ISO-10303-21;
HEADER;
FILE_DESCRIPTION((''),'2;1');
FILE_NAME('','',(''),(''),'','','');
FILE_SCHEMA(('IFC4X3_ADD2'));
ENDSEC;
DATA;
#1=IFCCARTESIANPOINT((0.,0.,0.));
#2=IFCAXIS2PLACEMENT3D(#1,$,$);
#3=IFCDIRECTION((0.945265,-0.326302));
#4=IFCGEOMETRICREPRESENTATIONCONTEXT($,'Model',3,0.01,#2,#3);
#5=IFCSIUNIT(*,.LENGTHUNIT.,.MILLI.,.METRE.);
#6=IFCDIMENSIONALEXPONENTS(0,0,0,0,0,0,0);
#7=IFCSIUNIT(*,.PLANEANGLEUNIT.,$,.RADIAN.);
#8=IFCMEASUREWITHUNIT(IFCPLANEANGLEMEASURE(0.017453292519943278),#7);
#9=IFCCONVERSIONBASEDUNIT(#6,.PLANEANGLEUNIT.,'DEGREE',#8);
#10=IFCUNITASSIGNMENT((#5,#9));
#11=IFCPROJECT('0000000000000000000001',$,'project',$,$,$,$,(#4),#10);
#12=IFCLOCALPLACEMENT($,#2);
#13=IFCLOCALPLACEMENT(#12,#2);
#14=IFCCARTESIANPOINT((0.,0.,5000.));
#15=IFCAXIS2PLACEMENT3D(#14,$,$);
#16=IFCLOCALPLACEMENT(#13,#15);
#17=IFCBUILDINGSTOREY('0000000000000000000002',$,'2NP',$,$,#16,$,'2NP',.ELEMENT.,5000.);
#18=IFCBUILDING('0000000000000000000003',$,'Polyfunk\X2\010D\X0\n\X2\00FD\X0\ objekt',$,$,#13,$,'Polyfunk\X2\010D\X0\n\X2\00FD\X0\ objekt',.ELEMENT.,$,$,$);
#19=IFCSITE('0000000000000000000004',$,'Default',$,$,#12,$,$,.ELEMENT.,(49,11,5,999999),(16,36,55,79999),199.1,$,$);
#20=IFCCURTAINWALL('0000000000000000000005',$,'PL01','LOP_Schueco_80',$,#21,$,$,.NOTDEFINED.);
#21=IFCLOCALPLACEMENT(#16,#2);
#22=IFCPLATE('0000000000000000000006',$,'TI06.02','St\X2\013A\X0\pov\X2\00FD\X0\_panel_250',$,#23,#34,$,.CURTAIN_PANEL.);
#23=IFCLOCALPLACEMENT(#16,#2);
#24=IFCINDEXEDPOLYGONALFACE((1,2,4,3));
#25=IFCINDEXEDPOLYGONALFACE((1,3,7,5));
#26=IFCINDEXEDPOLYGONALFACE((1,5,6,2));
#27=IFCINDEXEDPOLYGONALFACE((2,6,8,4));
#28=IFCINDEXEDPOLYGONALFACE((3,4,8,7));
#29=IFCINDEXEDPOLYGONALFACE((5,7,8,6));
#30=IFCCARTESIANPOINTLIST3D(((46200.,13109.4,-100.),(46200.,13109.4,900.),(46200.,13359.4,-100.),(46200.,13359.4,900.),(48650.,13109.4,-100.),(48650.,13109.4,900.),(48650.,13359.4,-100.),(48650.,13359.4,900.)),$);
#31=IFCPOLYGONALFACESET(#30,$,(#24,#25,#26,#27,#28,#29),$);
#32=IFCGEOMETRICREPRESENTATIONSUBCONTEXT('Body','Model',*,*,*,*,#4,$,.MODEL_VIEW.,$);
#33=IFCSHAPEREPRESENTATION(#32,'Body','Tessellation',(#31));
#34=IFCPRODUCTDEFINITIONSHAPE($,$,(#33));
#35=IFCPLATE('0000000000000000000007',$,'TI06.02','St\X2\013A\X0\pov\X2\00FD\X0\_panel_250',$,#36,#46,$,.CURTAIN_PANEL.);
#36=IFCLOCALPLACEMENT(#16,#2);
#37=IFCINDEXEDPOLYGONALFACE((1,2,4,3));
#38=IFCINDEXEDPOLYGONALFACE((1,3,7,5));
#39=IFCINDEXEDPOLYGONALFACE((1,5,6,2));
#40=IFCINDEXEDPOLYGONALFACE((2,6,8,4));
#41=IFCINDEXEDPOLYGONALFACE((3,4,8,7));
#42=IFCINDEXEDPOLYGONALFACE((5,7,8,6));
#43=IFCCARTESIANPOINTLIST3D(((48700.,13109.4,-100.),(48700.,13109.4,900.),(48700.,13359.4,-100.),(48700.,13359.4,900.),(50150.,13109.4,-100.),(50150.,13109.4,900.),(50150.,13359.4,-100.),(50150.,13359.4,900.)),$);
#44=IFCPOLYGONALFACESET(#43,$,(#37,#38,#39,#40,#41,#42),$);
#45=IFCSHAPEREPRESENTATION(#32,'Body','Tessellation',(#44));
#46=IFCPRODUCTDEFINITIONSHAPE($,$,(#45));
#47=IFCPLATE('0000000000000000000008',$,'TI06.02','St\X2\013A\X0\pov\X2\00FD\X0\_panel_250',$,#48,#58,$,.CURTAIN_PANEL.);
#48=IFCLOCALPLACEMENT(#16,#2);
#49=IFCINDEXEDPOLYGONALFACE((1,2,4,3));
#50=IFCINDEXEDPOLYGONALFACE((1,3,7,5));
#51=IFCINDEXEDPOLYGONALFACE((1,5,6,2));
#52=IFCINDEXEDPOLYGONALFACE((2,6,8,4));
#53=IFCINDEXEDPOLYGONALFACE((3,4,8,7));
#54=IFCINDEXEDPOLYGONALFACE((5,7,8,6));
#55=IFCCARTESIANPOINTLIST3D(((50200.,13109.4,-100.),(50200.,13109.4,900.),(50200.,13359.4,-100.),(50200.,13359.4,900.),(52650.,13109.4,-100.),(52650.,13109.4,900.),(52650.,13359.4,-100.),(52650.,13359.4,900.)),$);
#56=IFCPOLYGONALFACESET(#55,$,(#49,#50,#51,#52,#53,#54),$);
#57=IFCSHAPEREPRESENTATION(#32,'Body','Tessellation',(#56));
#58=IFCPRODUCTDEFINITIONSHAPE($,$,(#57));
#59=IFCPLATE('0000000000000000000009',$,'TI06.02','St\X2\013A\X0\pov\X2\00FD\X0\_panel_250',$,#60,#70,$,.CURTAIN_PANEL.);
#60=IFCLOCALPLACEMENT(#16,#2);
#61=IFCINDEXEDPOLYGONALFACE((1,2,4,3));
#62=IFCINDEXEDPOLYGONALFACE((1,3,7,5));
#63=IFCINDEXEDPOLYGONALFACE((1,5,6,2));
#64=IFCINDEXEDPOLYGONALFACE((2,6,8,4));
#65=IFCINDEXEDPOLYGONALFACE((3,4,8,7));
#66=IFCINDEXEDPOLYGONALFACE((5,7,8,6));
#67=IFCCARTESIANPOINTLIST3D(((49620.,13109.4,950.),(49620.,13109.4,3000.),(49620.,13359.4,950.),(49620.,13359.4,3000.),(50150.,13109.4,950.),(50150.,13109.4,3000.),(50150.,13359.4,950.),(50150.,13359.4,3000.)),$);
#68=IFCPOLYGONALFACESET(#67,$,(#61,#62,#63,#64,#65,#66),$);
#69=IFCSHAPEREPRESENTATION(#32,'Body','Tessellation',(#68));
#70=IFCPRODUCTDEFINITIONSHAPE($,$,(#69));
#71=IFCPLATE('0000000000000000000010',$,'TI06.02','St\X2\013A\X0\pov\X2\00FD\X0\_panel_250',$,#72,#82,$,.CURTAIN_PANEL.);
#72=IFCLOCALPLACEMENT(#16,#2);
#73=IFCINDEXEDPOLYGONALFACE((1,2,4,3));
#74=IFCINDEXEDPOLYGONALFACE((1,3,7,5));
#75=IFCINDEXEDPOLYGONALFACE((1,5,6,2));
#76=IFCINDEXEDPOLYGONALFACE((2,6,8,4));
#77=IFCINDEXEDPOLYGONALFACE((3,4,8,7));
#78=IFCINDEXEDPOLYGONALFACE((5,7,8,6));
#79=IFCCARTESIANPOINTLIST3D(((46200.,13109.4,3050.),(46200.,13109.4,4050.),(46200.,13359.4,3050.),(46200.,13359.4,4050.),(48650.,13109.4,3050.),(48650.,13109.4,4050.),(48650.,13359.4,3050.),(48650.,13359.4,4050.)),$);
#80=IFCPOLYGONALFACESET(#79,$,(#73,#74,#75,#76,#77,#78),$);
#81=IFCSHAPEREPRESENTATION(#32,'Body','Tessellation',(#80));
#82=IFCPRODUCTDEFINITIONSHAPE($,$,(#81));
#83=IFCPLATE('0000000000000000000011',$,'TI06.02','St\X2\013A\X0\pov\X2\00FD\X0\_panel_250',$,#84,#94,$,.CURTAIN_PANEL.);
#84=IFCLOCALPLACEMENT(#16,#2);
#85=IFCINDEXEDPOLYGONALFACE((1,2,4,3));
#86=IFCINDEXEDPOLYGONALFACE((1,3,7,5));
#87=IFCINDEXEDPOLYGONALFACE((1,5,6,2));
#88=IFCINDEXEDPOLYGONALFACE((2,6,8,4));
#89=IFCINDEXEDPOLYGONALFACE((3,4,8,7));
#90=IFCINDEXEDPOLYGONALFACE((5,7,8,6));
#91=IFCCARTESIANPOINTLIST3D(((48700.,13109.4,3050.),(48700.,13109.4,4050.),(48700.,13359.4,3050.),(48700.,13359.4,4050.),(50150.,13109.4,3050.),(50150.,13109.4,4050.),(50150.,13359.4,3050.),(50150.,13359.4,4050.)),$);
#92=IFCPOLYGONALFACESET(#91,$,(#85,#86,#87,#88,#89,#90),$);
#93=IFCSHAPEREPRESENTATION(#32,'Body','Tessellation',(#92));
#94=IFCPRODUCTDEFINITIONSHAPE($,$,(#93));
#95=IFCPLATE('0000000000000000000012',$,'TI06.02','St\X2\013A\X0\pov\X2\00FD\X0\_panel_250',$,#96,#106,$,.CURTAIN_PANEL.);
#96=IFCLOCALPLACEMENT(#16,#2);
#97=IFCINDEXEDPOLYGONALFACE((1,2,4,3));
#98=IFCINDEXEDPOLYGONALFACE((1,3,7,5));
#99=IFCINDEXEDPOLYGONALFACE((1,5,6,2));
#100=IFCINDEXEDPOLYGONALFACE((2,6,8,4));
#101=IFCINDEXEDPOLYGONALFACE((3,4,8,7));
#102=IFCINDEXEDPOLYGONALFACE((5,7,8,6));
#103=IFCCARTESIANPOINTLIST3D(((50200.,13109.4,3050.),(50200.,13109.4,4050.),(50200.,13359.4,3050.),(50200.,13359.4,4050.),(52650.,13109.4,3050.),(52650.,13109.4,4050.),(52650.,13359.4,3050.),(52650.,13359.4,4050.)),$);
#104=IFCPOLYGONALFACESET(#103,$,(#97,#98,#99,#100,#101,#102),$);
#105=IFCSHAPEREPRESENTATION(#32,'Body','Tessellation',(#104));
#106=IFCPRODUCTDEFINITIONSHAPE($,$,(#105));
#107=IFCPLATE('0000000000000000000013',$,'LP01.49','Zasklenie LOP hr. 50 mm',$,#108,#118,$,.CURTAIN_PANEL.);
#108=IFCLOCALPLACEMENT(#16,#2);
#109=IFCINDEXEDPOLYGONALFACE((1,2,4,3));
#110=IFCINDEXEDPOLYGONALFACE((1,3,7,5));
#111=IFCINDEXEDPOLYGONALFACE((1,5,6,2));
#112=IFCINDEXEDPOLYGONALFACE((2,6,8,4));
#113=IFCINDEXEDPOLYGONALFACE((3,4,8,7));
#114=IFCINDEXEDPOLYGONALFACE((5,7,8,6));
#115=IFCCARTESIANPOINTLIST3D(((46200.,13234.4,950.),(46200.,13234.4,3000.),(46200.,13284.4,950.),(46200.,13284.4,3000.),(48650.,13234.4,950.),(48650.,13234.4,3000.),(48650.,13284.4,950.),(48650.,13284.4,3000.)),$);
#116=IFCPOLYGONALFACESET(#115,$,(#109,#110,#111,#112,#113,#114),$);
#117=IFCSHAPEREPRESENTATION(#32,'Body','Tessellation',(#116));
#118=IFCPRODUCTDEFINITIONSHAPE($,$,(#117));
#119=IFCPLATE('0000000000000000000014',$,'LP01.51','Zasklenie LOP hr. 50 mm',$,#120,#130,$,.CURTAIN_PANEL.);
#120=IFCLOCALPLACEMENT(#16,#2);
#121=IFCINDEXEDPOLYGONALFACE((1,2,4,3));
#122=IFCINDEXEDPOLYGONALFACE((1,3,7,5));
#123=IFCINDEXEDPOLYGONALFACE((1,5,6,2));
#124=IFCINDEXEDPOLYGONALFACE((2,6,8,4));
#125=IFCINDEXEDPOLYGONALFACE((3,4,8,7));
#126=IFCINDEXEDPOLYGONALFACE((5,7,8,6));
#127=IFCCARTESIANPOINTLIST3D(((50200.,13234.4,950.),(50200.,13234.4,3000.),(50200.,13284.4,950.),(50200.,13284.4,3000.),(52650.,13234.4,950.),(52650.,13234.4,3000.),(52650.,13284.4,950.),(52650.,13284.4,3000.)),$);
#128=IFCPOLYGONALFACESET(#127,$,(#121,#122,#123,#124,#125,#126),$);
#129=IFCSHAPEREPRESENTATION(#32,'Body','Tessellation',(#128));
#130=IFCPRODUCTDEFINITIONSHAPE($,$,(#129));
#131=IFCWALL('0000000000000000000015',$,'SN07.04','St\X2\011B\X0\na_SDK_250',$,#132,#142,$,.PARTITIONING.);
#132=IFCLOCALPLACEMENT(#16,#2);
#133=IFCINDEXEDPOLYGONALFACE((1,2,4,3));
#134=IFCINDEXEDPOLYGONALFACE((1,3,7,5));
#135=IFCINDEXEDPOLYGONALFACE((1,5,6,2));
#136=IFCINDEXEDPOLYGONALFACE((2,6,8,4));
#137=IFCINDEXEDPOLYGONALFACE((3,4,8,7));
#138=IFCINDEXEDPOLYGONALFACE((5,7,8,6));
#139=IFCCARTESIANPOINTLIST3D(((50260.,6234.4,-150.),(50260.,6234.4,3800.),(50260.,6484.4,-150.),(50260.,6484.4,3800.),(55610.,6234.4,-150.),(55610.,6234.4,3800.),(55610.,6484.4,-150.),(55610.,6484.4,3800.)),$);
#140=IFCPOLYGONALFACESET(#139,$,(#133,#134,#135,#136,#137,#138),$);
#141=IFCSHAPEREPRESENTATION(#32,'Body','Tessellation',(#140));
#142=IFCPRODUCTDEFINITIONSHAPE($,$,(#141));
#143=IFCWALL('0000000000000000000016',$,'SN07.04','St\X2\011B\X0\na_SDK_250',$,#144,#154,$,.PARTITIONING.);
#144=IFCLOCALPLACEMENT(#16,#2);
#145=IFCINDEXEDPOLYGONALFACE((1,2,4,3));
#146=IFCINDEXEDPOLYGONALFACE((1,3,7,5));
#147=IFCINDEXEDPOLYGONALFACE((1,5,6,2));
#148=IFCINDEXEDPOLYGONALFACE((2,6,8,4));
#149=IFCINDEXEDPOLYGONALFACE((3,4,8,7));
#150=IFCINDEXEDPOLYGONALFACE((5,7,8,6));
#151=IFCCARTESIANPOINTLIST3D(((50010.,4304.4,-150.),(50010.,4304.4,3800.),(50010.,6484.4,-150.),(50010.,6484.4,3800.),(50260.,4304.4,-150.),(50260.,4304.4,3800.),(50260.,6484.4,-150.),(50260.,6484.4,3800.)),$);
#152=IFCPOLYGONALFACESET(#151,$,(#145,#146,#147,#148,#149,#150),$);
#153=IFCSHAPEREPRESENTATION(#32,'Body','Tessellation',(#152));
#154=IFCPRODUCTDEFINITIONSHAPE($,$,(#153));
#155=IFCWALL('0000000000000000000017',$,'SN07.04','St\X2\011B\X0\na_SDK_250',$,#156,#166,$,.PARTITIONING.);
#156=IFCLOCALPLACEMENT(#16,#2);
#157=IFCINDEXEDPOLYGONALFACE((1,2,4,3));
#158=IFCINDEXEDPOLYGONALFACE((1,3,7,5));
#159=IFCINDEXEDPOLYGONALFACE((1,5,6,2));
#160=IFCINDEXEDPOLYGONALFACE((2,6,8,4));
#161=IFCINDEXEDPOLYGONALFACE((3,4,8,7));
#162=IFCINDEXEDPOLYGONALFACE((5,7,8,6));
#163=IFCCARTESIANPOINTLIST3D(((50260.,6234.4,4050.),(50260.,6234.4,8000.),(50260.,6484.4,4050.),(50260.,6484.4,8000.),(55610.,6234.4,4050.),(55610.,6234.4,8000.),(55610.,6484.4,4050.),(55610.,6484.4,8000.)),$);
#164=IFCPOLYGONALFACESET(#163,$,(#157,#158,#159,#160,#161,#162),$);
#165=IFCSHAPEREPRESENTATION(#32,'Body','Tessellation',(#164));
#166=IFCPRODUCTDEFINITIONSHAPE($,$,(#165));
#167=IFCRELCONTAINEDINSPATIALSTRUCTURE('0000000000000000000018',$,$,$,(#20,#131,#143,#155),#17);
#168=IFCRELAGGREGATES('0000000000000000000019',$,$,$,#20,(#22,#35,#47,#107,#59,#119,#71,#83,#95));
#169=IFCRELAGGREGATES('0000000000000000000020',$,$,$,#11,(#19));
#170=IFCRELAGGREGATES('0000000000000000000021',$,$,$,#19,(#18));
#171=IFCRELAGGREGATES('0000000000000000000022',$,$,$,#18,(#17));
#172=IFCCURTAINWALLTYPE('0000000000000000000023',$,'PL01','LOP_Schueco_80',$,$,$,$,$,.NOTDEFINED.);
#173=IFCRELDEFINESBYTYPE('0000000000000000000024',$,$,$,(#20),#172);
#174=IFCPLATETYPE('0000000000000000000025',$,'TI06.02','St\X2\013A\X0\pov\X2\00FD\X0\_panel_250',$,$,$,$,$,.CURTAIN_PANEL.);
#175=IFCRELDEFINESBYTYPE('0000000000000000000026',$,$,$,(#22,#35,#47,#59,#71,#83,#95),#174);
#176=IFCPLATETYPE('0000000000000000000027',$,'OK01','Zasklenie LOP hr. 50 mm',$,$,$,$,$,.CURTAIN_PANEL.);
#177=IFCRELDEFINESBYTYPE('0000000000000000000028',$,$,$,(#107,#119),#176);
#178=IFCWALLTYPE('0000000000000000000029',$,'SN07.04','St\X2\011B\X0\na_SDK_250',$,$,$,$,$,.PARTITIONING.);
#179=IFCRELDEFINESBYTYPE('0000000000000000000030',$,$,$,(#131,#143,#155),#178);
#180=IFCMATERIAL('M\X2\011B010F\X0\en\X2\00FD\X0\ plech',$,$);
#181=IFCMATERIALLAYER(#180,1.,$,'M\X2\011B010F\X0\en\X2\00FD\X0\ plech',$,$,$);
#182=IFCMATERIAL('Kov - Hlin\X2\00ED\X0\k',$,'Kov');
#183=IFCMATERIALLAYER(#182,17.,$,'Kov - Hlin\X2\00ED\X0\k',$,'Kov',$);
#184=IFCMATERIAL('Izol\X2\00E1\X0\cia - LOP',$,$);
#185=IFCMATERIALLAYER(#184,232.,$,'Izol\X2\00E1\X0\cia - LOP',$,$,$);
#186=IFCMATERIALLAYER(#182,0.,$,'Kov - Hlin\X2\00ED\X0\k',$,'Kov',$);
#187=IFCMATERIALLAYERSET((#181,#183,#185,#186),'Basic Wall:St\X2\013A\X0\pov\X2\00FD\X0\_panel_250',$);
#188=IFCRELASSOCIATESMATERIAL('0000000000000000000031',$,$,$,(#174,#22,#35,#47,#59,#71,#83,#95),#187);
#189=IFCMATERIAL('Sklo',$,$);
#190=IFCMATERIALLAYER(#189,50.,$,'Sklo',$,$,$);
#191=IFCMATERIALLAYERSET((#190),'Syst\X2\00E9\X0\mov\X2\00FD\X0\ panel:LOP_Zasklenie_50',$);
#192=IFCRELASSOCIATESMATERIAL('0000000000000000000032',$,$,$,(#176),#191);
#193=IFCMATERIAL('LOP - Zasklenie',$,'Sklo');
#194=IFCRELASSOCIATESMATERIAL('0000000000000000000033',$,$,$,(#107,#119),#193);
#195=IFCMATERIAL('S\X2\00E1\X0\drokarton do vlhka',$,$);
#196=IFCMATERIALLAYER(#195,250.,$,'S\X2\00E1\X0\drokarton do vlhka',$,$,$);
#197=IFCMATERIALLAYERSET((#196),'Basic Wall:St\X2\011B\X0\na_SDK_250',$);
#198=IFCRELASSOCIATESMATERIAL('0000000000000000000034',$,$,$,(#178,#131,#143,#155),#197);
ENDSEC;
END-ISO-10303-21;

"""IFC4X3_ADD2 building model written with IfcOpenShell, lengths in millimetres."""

from ifc_helpers import new_model, entity, si_unit, converted_unit, direction, frame, frame_2d, origin, origin_2d_with_axis, place, context, subcontext, project, spatial, polyline, rectangle, extrude, clip, bounded_halfspace, source, transform, mapped, material, layer, layer_set, layer_usage, type_object, type_shapes, element, aggregate, save


model = new_model("IFC4X3_ADD2")

# Units and contexts
model_context = context("Model", 3, precision=0.01, world=origin(), true_north=direction((0.945265, -0.326302)))
body_context = subcontext(model_context, "Body", "Model", "MODEL_VIEW")
ifc_project = project(units=[si_unit("LENGTHUNIT", "METRE", prefix="MILLI"), converted_unit("PLANEANGLEUNIT", "DEGREE", entity("IfcPlaneAngleMeasure", 0.017453292519943278), si_unit("PLANEANGLEUNIT", "RADIAN"), dimensions=[0, 0, 0, 0, 0, 0, 0])], contexts=[model_context])

# Site, building, storey
site_placement = place(None, origin())
site = spatial("IfcSite", under=ifc_project, at=site_placement, Name="Default", CompositionType="ELEMENT", RefLatitude=(49, 11, 5, 999999), RefLongitude=(16, 36, 55, 79999), RefElevation=199.1)
building_placement = place(site_placement, origin())
building = spatial("IfcBuilding", under=site, at=building_placement, Name="Polyfunkčný objekt", LongName="Polyfunkčný objekt", CompositionType="ELEMENT")
storey_placement = place(building_placement, frame((0.0, 0.0, 5000.0)))
storey = spatial("IfcBuildingStorey", under=building, at=storey_placement, Name="2NP", LongName="2NP", CompositionType="ELEMENT", Elevation=5000.0)

# Curtain wall, plates
curtain_wall_type = type_object("IfcCurtainWallType", Name="PL01", Description="LOP_Schueco_80", PredefinedType="NOTDEFINED")
curtain_wall_placement = place(storey_placement, frame((0.0, 0.0, -5000.0)))
curtain_wall = element("IfcCurtainWall", 1, at=curtain_wall_placement, inside=storey, type_object=curtain_wall_type, Name="PL01", Description="LOP_Schueco_80", PredefinedType="NOTDEFINED")
ifc_material_1 = material(Name="Měďený plech")
ifc_layer_1 = layer(ifc_material_1, 1.0, Name="Měďený plech")
ifc_material_2 = material(Name="Kov - Hliník", Category="Kov")
ifc_layer_2 = layer(ifc_material_2, 17.0, Name="Kov - Hliník", Category="Kov")
ifc_material_3 = material(Name="Izolácia - LOP")
ifc_layer_3 = layer(ifc_material_3, 232.0, Name="Izolácia - LOP")
ifc_layer_4 = layer(ifc_material_2, 0.0, Name="Kov - Hliník", Category="Kov")
ifc_layer_set_1 = layer_set([ifc_layer_1, ifc_layer_2, ifc_layer_3, ifc_layer_4], Name="Basic Wall:Stĺpový_panel_250")
ifc_layer_usage_1 = layer_usage(ifc_layer_set_1, "AXIS2", "NEGATIVE", 125.0)
plate_type_1 = type_object("IfcPlateType", Name="TI06.02", Description="Stĺpový_panel_250", PredefinedType="CURTAIN_PANEL", material=ifc_layer_set_1)
plate_1_placement = place(storey_placement, frame((46200.0, 13234.4, -100.0)))
plate_1 = element("IfcPlate", 2, at=plate_1_placement, type_object=plate_type_1, material=ifc_layer_usage_1, Name="TI06.02", Description="Stĺpový_panel_250", PredefinedType="CURTAIN_PANEL", context=body_context, shape_type="SweptSolid", body=[
    extrude(rectangle(XDim=250.0, YDim=2450.0, at=frame_2d((0.0, 0.0), x_axis=(1.0, 0.0))), frame((1225.0, 0.0, 0.0), z_axis=(0.0, 0.0, 1.0), x_axis=(0.0, 1.0, 0.0)), (0.0, 0.0, 1.0), 1000.0),
])
ifc_layer_usage_2 = layer_usage(ifc_layer_set_1, "AXIS2", "NEGATIVE", 125.0)
plate_2_placement = place(storey_placement, frame((48700.0, 13234.4, -100.0)))
plate_2 = element("IfcPlate", 3, at=plate_2_placement, type_object=plate_type_1, material=ifc_layer_usage_2, Name="TI06.02", Description="Stĺpový_panel_250", PredefinedType="CURTAIN_PANEL", context=body_context, shape_type="SweptSolid", body=[
    extrude(rectangle(XDim=250.0, YDim=1450.0, at=frame_2d((0.0, 0.0), x_axis=(1.0, 0.0))), frame((725.0, 0.0, 0.0), z_axis=(0.0, 0.0, 1.0), x_axis=(0.0, 1.0, 0.0)), (0.0, 0.0, 1.0), 1000.0),
])
ifc_layer_usage_3 = layer_usage(ifc_layer_set_1, "AXIS2", "NEGATIVE", 125.0)
plate_3_placement = place(storey_placement, frame((50200.0, 13234.4, -100.0)))
plate_3 = element("IfcPlate", 4, at=plate_3_placement, type_object=plate_type_1, material=ifc_layer_usage_3, Name="TI06.02", Description="Stĺpový_panel_250", PredefinedType="CURTAIN_PANEL", context=body_context, shape_type="SweptSolid", body=[
    extrude(rectangle(XDim=250.0, YDim=2450.0, at=origin_2d_with_axis()), frame((1225.0, 0.0, 0.0), z_axis=(0.0, 0.0, 1.0), x_axis=(0.0, 1.0, 0.0)), (0.0, 0.0, 1.0), 1000.0),
])
ifc_layer_usage_4 = layer_usage(ifc_layer_set_1, "AXIS2", "NEGATIVE", 125.0)
plate_4_placement = place(storey_placement, frame((49620.0, 13234.4, 950.0)))
plate_4 = element("IfcPlate", 5, at=plate_4_placement, type_object=plate_type_1, material=ifc_layer_usage_4, Name="TI06.02", Description="Stĺpový_panel_250", PredefinedType="CURTAIN_PANEL", context=body_context, shape_type="SweptSolid", body=[
    extrude(rectangle(XDim=250.0, YDim=530.0, at=frame_2d((0.0, 0.0), x_axis=(1.0, 0.0))), frame((265.0, 0.0, 0.0), z_axis=(0.0, 0.0, 1.0), x_axis=(0.0, 1.0, 0.0)), (0.0, 0.0, 1.0), 2050.0),
])
ifc_layer_usage_5 = layer_usage(ifc_layer_set_1, "AXIS2", "NEGATIVE", 125.0)
plate_5_placement = place(storey_placement, frame((46200.0, 13234.4, 3050.0)))
plate_5 = element("IfcPlate", 6, at=plate_5_placement, type_object=plate_type_1, material=ifc_layer_usage_5, Name="TI06.02", Description="Stĺpový_panel_250", PredefinedType="CURTAIN_PANEL", context=body_context, shape_type="SweptSolid", body=[
    extrude(rectangle(XDim=250.0, YDim=2450.0, at=frame_2d((0.0, 0.0), x_axis=(1.0, 0.0))), frame((1225.0, 0.0, 0.0), z_axis=(0.0, 0.0, 1.0), x_axis=(0.0, 1.0, 0.0)), (0.0, 0.0, 1.0), 1000.0),
])
ifc_layer_usage_6 = layer_usage(ifc_layer_set_1, "AXIS2", "NEGATIVE", 125.0)
plate_6_placement = place(storey_placement, frame((48700.0, 13234.4, 3050.0)))
plate_6 = element("IfcPlate", 7, at=plate_6_placement, type_object=plate_type_1, material=ifc_layer_usage_6, Name="TI06.02", Description="Stĺpový_panel_250", PredefinedType="CURTAIN_PANEL", context=body_context, shape_type="SweptSolid", body=[
    extrude(rectangle(XDim=250.0, YDim=1450.0, at=frame_2d((0.0, 0.0), x_axis=(1.0, 0.0))), frame((725.0, 0.0, 0.0), z_axis=(0.0, 0.0, 1.0), x_axis=(0.0, 1.0, 0.0)), (0.0, 0.0, 1.0), 1000.0),
])
ifc_layer_usage_7 = layer_usage(ifc_layer_set_1, "AXIS2", "NEGATIVE", 125.0)
plate_7_placement = place(storey_placement, frame((50200.0, 13234.4, 3050.0)))
plate_7 = element("IfcPlate", 8, at=plate_7_placement, type_object=plate_type_1, material=ifc_layer_usage_7, Name="TI06.02", Description="Stĺpový_panel_250", PredefinedType="CURTAIN_PANEL", context=body_context, shape_type="SweptSolid", body=[
    extrude(rectangle(XDim=250.0, YDim=2450.0, at=origin_2d_with_axis()), frame((1225.0, 0.0, 0.0), z_axis=(0.0, 0.0, 1.0), x_axis=(0.0, 1.0, 0.0)), (0.0, 0.0, 1.0), 1000.0),
])
ifc_material_4 = material(Name="LOP - Zasklenie", Category="Sklo")
ifc_material_5 = material(Name="Sklo")
ifc_layer_5 = layer(ifc_material_5, 50.0, Name="Sklo")
ifc_layer_set_2 = layer_set([ifc_layer_5], Name="Systémový panel:LOP_Zasklenie_50")
plate_type_2 = type_object("IfcPlateType", Name="OK01", Description="Zasklenie LOP hr. 50 mm", PredefinedType="CURTAIN_PANEL", material=ifc_layer_set_2)
shared_shape_1 = source(origin(), body_context, "Body", "SweptSolid", [
    extrude(rectangle(XDim=50.0, YDim=2450.0, at=origin_2d_with_axis()), frame((0.0, 25.0, 0.0), z_axis=(0.0, 0.0, 1.0), x_axis=(0.0, 1.0, 0.0)), (0.0, 0.0, 1.0), 2050.0),
])
type_shapes(plate_type_2, [shared_shape_1])
plate_8_placement = place(curtain_wall_placement, frame((47425.0, 13234.4, 5950.0)))
plate_8 = element("IfcPlate", 9, at=plate_8_placement, type_object=plate_type_2, material=ifc_material_4, Name="LP01.49", Description="Zasklenie LOP hr. 50 mm", PredefinedType="CURTAIN_PANEL", context=body_context, shape_type="MappedRepresentation", body=[
    mapped(shared_shape_1, transform((0.0, 0.0, 0.0), scale=1.0)),
])
plate_9_placement = place(curtain_wall_placement, frame((51425.0, 13234.4, 5950.0)))
plate_9 = element("IfcPlate", 10, at=plate_9_placement, type_object=plate_type_2, material=ifc_material_4, Name="LP01.51", Description="Zasklenie LOP hr. 50 mm", PredefinedType="CURTAIN_PANEL", context=body_context, shape_type="MappedRepresentation", body=[
    mapped(shared_shape_1, transform((0.0, 0.0, 0.0), scale=1.0)),
])

# Walls
ifc_material_6 = material(Name="Sádrokarton do vlhka")
ifc_layer_6 = layer(ifc_material_6, 250.0, Name="Sádrokarton do vlhka")
ifc_layer_set_3 = layer_set([ifc_layer_6], Name="Basic Wall:Stěna_SDK_250")
wall_type_1 = type_object("IfcWallType", Name="SN07.04", Description="Stěna_SDK_250", PredefinedType="PARTITIONING", material=ifc_layer_set_3)
wall_1_placement = place(storey_placement, frame((50260.0, 6359.4, -150.0)))
element("IfcWall", 11, at=wall_1_placement, inside=storey, type_object=wall_type_1, material=ifc_layer_set_3, Name="SN07.04", Description="Stěna_SDK_250", PredefinedType="PARTITIONING", context=body_context, shape_type="Clipping", body=[
    clip(clip(extrude(rectangle(XDim=5350.0, YDim=250.0, at=frame_2d((2675.0, 0.0), x_axis=(-1.0, 0.0))), origin(), (0.0, 0.0, 1.0), 3950.0), bounded_halfspace(frame((5350.0, -125.0, 0.0), z_axis=(0.0, 0.0, 1.0), x_axis=(-1.0, 0.0, 0.0)), True, frame((5350.0, -125.0, 0.0)), polyline([(0.0, 0.0), (0.0, 250.0), (-5350.0, 250.0), (-5350.0, 0.0), (-1670.0, 0.0), (-1520.0, 0.0), (0.0, 0.0)]))), bounded_halfspace(frame((0.0, -125.0, 3950.0), z_axis=(0.0, 0.0, -1.0), x_axis=(1.0, 0.0, 0.0)), True, frame((0.0, -125.0, 3950.0)), polyline([(0.0, 0.0), (3680.0, 0.0), (3830.0, 0.0), (5350.0, 0.0), (5350.0, 250.0), (0.0, 250.0), (0.0, 0.0)]))),
])
wall_2_placement = place(storey_placement, frame((50135.0, 6484.4, -150.0), z_axis=(0.0, 0.0, 1.0), x_axis=(0.0, -1.0, 0.0)))
element("IfcWall", 12, at=wall_2_placement, inside=storey, type_object=wall_type_1, material=ifc_layer_set_3, Name="SN07.04", Description="Stěna_SDK_250", PredefinedType="PARTITIONING", context=body_context, shape_type="Clipping", body=[
    clip(clip(extrude(rectangle(XDim=2180.0, YDim=250.0, at=frame_2d((1090.0, 0.0), x_axis=(-1.0, 0.0))), origin(), (0.0, 0.0, 1.0), 3950.0), bounded_halfspace(frame((2180.0, -125.0, 0.0), z_axis=(0.0, 0.0, 1.0), x_axis=(0.0, -1.0, 0.0)), True, frame((2180.0, -125.0, 0.0)), polyline([(0.0, 0.0), (0.0, 250.0), (-1930.0, 250.0), (-2180.0, 250.0), (-2180.0, 0.0), (0.0, 0.0)]))), bounded_halfspace(frame((0.0, -125.0, 3950.0), z_axis=(0.0, 0.0, -1.0), x_axis=(0.0, 1.0, 0.0)), True, frame((0.0, -125.0, 3950.0)), polyline([(0.0, 0.0), (2180.0, 0.0), (2180.0, 250.0), (250.0, 250.0), (0.0, 250.0), (0.0, 0.0)]))),
])
wall_3_placement = place(storey_placement, frame((50260.0, 6359.4, 4050.0)))
element("IfcWall", 13, at=wall_3_placement, inside=storey, type_object=wall_type_1, material=ifc_layer_set_3, Name="SN07.04", Description="Stěna_SDK_250", PredefinedType="PARTITIONING", context=body_context, shape_type="Clipping", body=[
    clip(clip(extrude(rectangle(XDim=5350.0, YDim=250.0, at=frame_2d((2675.0, 0.0), x_axis=(-1.0, 0.0))), origin(), (0.0, 0.0, 1.0), 3950.0), bounded_halfspace(frame((5350.0, -125.0, 0.0), z_axis=(0.0, 0.0, 1.0), x_axis=(-1.0, 0.0, 0.0)), True, frame((5350.0, -125.0, 0.0)), polyline([(0.0, 0.0), (0.0, 250.0), (-5350.0, 250.0), (-5350.0, 0.0), (-1670.0, 0.0), (-1520.0, 0.0), (0.0, 0.0)]))), bounded_halfspace(frame((0.0, -125.0, 3950.0), z_axis=(0.0, 0.0, -1.0), x_axis=(1.0, 0.0, 0.0)), True, frame((0.0, -125.0, 3950.0)), polyline([(0.0, 0.0), (3680.0, 0.0), (3830.0, 0.0), (5350.0, 0.0), (5350.0, 250.0), (0.0, 250.0), (0.0, 0.0)]))),
])

aggregate(curtain_wall, [plate_1, plate_2, plate_3, plate_8, plate_4, plate_9, plate_5, plate_6, plate_7])

save(model, "model.ifc")
